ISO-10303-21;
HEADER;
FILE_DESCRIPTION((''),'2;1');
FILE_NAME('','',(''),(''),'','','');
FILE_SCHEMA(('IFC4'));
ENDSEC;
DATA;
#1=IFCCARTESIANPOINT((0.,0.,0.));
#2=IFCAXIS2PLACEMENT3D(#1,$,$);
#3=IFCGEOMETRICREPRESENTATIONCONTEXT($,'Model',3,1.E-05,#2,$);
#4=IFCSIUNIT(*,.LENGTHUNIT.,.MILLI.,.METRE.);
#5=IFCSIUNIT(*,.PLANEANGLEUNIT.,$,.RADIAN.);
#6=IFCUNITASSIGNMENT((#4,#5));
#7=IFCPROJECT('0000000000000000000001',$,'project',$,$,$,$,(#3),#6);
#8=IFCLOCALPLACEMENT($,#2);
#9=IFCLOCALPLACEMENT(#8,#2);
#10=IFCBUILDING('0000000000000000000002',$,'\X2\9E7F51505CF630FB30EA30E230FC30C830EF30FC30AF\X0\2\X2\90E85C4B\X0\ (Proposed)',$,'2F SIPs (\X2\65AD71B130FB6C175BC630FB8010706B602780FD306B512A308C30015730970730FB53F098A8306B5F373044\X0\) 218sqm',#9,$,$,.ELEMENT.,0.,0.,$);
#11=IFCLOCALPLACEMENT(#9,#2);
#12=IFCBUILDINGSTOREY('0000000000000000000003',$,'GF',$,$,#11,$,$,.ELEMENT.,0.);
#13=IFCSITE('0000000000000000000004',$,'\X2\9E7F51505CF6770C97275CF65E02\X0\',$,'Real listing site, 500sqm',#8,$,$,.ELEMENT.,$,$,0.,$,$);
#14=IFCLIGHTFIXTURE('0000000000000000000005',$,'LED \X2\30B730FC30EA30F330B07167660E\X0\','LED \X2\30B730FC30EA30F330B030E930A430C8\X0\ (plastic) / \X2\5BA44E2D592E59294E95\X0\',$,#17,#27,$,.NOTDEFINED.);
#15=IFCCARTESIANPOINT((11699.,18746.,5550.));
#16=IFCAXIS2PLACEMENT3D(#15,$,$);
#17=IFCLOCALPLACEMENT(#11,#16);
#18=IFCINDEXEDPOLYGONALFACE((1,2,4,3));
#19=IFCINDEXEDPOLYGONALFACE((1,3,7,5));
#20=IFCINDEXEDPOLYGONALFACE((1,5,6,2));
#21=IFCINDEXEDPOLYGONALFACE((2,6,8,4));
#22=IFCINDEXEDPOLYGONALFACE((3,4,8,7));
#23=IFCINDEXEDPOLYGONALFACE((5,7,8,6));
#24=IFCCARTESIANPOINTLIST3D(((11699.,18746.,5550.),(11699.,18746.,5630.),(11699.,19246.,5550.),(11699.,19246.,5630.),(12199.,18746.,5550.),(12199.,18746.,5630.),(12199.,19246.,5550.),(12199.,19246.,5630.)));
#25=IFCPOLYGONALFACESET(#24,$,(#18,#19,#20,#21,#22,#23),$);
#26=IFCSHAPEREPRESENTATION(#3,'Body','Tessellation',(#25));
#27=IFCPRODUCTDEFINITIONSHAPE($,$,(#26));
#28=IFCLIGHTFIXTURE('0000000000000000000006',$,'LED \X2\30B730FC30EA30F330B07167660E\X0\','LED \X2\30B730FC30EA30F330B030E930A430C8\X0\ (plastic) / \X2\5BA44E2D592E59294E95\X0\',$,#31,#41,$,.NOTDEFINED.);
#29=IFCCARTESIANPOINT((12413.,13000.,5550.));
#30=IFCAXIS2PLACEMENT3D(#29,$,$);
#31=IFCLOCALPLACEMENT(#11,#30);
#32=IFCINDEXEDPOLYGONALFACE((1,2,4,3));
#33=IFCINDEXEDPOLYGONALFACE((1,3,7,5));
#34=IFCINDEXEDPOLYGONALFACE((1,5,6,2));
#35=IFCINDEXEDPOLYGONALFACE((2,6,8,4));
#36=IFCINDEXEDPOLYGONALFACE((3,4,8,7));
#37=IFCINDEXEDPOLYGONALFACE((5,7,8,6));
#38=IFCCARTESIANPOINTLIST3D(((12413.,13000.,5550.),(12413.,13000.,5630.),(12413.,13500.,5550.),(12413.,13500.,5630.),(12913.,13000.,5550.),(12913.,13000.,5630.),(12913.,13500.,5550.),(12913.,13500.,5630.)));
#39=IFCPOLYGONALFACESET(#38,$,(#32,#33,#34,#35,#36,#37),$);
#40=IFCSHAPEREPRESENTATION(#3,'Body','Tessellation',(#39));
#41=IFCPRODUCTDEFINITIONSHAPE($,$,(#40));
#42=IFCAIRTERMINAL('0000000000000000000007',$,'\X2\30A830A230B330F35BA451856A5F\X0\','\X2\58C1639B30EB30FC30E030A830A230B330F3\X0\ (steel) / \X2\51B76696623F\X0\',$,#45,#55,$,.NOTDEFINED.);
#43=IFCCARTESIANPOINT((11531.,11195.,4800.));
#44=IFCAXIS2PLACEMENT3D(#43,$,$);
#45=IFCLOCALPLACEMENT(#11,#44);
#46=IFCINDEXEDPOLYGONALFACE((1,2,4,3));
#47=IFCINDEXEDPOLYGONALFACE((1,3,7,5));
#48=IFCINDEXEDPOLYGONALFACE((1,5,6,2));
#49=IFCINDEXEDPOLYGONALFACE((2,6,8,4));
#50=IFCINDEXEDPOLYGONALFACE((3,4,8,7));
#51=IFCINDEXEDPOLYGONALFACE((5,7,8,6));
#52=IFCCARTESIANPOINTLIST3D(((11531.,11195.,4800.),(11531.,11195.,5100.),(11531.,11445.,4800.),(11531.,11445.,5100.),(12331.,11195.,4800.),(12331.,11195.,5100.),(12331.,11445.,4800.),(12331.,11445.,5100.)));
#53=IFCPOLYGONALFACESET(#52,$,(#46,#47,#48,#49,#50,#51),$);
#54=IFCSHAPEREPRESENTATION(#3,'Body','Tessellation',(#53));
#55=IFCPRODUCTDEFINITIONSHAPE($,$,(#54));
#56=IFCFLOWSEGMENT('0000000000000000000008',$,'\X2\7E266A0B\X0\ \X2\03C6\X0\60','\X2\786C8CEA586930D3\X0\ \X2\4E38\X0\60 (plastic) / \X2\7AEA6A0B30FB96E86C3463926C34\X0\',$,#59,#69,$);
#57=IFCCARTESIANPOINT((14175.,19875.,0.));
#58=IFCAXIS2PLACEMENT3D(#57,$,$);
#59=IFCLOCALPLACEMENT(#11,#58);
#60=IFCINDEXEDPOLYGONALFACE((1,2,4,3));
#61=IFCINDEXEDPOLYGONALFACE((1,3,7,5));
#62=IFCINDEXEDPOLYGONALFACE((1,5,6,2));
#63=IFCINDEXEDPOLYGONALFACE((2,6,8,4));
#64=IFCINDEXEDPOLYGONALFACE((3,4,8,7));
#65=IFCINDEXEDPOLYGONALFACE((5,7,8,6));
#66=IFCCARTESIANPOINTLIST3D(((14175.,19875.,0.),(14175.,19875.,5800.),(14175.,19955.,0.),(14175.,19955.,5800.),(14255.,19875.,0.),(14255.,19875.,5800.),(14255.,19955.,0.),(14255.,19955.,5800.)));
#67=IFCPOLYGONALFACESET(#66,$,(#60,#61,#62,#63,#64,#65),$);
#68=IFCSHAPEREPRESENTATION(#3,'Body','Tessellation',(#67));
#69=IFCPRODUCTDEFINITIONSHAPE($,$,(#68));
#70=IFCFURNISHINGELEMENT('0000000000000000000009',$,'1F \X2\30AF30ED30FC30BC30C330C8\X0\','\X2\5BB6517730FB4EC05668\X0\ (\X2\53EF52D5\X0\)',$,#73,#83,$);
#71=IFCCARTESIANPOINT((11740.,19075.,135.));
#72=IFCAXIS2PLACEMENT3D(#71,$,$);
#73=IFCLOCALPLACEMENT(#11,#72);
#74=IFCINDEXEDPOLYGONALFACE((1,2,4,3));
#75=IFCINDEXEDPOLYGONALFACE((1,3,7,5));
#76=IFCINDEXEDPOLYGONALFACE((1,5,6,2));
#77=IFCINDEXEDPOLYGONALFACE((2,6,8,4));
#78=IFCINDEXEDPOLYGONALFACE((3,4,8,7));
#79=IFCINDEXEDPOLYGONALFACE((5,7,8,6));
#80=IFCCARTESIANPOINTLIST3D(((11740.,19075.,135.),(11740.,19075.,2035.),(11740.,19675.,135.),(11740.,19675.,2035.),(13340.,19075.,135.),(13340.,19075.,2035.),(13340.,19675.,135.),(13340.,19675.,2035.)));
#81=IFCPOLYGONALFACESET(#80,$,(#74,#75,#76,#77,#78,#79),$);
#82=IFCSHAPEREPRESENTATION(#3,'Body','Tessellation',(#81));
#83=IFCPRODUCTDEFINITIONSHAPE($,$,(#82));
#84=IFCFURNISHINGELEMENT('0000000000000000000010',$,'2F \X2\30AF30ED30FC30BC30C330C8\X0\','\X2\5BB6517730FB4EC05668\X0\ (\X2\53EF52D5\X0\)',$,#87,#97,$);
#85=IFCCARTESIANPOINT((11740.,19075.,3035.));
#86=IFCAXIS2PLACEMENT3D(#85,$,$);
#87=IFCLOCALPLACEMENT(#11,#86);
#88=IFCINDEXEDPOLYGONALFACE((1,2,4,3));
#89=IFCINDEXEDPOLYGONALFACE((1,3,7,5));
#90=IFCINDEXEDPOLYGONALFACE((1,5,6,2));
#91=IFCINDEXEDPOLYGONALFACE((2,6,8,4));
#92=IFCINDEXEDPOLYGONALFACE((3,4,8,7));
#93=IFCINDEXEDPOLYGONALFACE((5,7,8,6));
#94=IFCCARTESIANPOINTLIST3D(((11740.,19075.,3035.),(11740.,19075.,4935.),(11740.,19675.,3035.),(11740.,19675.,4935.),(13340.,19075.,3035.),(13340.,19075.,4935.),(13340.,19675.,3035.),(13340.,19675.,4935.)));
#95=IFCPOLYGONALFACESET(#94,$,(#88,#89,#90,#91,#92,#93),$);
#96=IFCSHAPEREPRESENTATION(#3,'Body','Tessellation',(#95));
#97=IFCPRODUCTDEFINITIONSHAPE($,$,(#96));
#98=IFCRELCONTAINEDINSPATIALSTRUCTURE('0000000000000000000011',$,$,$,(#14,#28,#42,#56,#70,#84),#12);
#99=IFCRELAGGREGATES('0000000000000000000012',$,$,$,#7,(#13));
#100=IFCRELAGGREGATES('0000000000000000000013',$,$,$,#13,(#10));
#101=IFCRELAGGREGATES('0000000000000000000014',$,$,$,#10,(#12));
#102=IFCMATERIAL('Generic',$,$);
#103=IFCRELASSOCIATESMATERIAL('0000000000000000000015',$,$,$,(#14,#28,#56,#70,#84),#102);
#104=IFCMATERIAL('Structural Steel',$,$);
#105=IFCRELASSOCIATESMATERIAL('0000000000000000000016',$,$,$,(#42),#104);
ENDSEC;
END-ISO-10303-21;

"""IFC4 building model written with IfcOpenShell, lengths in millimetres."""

from ifc_helpers import new_model, si_unit, frame, frame_2d, origin, place, context, project, spatial, rectangle, extrude, material, element, save


model = new_model("IFC4")

# Units and contexts
model_context = context("Model", 3, precision=1e-05, world=origin())
ifc_project = project(units=[si_unit("LENGTHUNIT", "METRE", prefix="MILLI"), si_unit("PLANEANGLEUNIT", "RADIAN")], contexts=[model_context])

# Site, building, storey
site_placement = place(None, origin())
site = spatial("IfcSite", under=ifc_project, at=site_placement, Name="鹿児島県霧島市", ObjectType="Real listing site, 500sqm", CompositionType="ELEMENT", RefElevation=0.0)
building_placement = place(site_placement, origin())
building = spatial("IfcBuilding", under=site, at=building_placement, Name="鹿児島・リモートワーク2部屋 (Proposed)", ObjectType="2F SIPs (断熱・気密・耐火性能に優れ、地震・台風に強い) 218sqm", CompositionType="ELEMENT", ElevationOfRefHeight=0.0, ElevationOfTerrain=0.0)
storey_placement = place(building_placement, origin())
storey = spatial("IfcBuildingStorey", under=building, at=storey_placement, Name="GF", CompositionType="ELEMENT", Elevation=0.0)

# Shared definitions
ifc_material_1 = material(Name="Structural Steel")

# Light fixtures
ifc_material_2 = material(Name="Generic")
light_fixture_1_placement = place(storey_placement, frame((11699.0, 18746.0, 5550.0)))
element("IfcLightFixture", 1, at=light_fixture_1_placement, inside=storey, material=ifc_material_2, Name="LED シーリング照明", Description="LED シーリングライト (plastic) / 室中央天井", PredefinedType="NOTDEFINED", context=model_context, shape_type="SweptSolid", body=[
    extrude(rectangle(XDim=500.0, YDim=500.0, at=frame_2d((250.0, 250.0))), frame((11699.0, 18746.0, 5550.0)), (0.0, 0.0, 1.0), 80.0),
])
light_fixture_2_placement = place(storey_placement, frame((12413.0, 13000.0, 5550.0)))
element("IfcLightFixture", 2, at=light_fixture_2_placement, inside=storey, material=ifc_material_2, Name="LED シーリング照明", Description="LED シーリングライト (plastic) / 室中央天井", PredefinedType="NOTDEFINED", context=model_context, shape_type="SweptSolid", body=[
    extrude(rectangle(XDim=500.0, YDim=500.0, at=frame_2d((250.0, 250.0))), frame((12413.0, 13000.0, 5550.0)), (0.0, 0.0, 1.0), 80.0),
])

# Air terminal
air_terminal_placement = place(storey_placement, frame((11531.0, 11195.0, 4800.0)))
element("IfcAirTerminal", 3, at=air_terminal_placement, inside=storey, material=ifc_material_1, Name="エアコン室内機", Description="壁掛ルームエアコン (steel) / 冷暖房", PredefinedType="NOTDEFINED", context=model_context, shape_type="SweptSolid", body=[
    extrude(rectangle(XDim=800.0, YDim=250.0, at=frame_2d((400.0, 125.0))), frame((11531.0, 11195.0, 4800.0)), (0.0, 0.0, 1.0), 300.0),
])

# Flow segment
flow_segment_placement = place(storey_placement, frame((14175.0, 19875.0, 0.0)))
element("IfcFlowSegment", 4, at=flow_segment_placement, inside=storey, material=ifc_material_2, Name="縦樋 φ60", Description="硬質塩ビ 丸60 (plastic) / 竪樋・雨水排水", context=model_context, shape_type="SweptSolid", body=[
    extrude(rectangle(XDim=80.0, YDim=80.0, at=frame_2d((40.0, 40.0))), frame((14175.0, 19875.0, 0.0)), (0.0, 0.0, 1.0), 5800.0),
])

# Furnishing elements
furnishing_1_placement = place(storey_placement, frame((11740.0, 19075.0, 135.0)))
element("IfcFurnishingElement", 5, at=furnishing_1_placement, inside=storey, material=ifc_material_2, Name="1F クローゼット", Description="家具・什器 (可動)", context=model_context, shape_type="SweptSolid", body=[
    extrude(rectangle(XDim=1600.0, YDim=600.0, at=frame_2d((800.0, 300.0))), frame((11740.0, 19075.0, 135.0)), (0.0, 0.0, 1.0), 1900.0),
])
furnishing_2_placement = place(storey_placement, frame((11740.0, 19075.0, 3035.0)))
element("IfcFurnishingElement", 6, at=furnishing_2_placement, inside=storey, material=ifc_material_2, Name="2F クローゼット", Description="家具・什器 (可動)", context=model_context, shape_type="SweptSolid", body=[
    extrude(rectangle(XDim=1600.0, YDim=600.0, at=frame_2d((800.0, 300.0))), frame((11740.0, 19075.0, 3035.0)), (0.0, 0.0, 1.0), 1900.0),
])

save(model, "model.ifc")
